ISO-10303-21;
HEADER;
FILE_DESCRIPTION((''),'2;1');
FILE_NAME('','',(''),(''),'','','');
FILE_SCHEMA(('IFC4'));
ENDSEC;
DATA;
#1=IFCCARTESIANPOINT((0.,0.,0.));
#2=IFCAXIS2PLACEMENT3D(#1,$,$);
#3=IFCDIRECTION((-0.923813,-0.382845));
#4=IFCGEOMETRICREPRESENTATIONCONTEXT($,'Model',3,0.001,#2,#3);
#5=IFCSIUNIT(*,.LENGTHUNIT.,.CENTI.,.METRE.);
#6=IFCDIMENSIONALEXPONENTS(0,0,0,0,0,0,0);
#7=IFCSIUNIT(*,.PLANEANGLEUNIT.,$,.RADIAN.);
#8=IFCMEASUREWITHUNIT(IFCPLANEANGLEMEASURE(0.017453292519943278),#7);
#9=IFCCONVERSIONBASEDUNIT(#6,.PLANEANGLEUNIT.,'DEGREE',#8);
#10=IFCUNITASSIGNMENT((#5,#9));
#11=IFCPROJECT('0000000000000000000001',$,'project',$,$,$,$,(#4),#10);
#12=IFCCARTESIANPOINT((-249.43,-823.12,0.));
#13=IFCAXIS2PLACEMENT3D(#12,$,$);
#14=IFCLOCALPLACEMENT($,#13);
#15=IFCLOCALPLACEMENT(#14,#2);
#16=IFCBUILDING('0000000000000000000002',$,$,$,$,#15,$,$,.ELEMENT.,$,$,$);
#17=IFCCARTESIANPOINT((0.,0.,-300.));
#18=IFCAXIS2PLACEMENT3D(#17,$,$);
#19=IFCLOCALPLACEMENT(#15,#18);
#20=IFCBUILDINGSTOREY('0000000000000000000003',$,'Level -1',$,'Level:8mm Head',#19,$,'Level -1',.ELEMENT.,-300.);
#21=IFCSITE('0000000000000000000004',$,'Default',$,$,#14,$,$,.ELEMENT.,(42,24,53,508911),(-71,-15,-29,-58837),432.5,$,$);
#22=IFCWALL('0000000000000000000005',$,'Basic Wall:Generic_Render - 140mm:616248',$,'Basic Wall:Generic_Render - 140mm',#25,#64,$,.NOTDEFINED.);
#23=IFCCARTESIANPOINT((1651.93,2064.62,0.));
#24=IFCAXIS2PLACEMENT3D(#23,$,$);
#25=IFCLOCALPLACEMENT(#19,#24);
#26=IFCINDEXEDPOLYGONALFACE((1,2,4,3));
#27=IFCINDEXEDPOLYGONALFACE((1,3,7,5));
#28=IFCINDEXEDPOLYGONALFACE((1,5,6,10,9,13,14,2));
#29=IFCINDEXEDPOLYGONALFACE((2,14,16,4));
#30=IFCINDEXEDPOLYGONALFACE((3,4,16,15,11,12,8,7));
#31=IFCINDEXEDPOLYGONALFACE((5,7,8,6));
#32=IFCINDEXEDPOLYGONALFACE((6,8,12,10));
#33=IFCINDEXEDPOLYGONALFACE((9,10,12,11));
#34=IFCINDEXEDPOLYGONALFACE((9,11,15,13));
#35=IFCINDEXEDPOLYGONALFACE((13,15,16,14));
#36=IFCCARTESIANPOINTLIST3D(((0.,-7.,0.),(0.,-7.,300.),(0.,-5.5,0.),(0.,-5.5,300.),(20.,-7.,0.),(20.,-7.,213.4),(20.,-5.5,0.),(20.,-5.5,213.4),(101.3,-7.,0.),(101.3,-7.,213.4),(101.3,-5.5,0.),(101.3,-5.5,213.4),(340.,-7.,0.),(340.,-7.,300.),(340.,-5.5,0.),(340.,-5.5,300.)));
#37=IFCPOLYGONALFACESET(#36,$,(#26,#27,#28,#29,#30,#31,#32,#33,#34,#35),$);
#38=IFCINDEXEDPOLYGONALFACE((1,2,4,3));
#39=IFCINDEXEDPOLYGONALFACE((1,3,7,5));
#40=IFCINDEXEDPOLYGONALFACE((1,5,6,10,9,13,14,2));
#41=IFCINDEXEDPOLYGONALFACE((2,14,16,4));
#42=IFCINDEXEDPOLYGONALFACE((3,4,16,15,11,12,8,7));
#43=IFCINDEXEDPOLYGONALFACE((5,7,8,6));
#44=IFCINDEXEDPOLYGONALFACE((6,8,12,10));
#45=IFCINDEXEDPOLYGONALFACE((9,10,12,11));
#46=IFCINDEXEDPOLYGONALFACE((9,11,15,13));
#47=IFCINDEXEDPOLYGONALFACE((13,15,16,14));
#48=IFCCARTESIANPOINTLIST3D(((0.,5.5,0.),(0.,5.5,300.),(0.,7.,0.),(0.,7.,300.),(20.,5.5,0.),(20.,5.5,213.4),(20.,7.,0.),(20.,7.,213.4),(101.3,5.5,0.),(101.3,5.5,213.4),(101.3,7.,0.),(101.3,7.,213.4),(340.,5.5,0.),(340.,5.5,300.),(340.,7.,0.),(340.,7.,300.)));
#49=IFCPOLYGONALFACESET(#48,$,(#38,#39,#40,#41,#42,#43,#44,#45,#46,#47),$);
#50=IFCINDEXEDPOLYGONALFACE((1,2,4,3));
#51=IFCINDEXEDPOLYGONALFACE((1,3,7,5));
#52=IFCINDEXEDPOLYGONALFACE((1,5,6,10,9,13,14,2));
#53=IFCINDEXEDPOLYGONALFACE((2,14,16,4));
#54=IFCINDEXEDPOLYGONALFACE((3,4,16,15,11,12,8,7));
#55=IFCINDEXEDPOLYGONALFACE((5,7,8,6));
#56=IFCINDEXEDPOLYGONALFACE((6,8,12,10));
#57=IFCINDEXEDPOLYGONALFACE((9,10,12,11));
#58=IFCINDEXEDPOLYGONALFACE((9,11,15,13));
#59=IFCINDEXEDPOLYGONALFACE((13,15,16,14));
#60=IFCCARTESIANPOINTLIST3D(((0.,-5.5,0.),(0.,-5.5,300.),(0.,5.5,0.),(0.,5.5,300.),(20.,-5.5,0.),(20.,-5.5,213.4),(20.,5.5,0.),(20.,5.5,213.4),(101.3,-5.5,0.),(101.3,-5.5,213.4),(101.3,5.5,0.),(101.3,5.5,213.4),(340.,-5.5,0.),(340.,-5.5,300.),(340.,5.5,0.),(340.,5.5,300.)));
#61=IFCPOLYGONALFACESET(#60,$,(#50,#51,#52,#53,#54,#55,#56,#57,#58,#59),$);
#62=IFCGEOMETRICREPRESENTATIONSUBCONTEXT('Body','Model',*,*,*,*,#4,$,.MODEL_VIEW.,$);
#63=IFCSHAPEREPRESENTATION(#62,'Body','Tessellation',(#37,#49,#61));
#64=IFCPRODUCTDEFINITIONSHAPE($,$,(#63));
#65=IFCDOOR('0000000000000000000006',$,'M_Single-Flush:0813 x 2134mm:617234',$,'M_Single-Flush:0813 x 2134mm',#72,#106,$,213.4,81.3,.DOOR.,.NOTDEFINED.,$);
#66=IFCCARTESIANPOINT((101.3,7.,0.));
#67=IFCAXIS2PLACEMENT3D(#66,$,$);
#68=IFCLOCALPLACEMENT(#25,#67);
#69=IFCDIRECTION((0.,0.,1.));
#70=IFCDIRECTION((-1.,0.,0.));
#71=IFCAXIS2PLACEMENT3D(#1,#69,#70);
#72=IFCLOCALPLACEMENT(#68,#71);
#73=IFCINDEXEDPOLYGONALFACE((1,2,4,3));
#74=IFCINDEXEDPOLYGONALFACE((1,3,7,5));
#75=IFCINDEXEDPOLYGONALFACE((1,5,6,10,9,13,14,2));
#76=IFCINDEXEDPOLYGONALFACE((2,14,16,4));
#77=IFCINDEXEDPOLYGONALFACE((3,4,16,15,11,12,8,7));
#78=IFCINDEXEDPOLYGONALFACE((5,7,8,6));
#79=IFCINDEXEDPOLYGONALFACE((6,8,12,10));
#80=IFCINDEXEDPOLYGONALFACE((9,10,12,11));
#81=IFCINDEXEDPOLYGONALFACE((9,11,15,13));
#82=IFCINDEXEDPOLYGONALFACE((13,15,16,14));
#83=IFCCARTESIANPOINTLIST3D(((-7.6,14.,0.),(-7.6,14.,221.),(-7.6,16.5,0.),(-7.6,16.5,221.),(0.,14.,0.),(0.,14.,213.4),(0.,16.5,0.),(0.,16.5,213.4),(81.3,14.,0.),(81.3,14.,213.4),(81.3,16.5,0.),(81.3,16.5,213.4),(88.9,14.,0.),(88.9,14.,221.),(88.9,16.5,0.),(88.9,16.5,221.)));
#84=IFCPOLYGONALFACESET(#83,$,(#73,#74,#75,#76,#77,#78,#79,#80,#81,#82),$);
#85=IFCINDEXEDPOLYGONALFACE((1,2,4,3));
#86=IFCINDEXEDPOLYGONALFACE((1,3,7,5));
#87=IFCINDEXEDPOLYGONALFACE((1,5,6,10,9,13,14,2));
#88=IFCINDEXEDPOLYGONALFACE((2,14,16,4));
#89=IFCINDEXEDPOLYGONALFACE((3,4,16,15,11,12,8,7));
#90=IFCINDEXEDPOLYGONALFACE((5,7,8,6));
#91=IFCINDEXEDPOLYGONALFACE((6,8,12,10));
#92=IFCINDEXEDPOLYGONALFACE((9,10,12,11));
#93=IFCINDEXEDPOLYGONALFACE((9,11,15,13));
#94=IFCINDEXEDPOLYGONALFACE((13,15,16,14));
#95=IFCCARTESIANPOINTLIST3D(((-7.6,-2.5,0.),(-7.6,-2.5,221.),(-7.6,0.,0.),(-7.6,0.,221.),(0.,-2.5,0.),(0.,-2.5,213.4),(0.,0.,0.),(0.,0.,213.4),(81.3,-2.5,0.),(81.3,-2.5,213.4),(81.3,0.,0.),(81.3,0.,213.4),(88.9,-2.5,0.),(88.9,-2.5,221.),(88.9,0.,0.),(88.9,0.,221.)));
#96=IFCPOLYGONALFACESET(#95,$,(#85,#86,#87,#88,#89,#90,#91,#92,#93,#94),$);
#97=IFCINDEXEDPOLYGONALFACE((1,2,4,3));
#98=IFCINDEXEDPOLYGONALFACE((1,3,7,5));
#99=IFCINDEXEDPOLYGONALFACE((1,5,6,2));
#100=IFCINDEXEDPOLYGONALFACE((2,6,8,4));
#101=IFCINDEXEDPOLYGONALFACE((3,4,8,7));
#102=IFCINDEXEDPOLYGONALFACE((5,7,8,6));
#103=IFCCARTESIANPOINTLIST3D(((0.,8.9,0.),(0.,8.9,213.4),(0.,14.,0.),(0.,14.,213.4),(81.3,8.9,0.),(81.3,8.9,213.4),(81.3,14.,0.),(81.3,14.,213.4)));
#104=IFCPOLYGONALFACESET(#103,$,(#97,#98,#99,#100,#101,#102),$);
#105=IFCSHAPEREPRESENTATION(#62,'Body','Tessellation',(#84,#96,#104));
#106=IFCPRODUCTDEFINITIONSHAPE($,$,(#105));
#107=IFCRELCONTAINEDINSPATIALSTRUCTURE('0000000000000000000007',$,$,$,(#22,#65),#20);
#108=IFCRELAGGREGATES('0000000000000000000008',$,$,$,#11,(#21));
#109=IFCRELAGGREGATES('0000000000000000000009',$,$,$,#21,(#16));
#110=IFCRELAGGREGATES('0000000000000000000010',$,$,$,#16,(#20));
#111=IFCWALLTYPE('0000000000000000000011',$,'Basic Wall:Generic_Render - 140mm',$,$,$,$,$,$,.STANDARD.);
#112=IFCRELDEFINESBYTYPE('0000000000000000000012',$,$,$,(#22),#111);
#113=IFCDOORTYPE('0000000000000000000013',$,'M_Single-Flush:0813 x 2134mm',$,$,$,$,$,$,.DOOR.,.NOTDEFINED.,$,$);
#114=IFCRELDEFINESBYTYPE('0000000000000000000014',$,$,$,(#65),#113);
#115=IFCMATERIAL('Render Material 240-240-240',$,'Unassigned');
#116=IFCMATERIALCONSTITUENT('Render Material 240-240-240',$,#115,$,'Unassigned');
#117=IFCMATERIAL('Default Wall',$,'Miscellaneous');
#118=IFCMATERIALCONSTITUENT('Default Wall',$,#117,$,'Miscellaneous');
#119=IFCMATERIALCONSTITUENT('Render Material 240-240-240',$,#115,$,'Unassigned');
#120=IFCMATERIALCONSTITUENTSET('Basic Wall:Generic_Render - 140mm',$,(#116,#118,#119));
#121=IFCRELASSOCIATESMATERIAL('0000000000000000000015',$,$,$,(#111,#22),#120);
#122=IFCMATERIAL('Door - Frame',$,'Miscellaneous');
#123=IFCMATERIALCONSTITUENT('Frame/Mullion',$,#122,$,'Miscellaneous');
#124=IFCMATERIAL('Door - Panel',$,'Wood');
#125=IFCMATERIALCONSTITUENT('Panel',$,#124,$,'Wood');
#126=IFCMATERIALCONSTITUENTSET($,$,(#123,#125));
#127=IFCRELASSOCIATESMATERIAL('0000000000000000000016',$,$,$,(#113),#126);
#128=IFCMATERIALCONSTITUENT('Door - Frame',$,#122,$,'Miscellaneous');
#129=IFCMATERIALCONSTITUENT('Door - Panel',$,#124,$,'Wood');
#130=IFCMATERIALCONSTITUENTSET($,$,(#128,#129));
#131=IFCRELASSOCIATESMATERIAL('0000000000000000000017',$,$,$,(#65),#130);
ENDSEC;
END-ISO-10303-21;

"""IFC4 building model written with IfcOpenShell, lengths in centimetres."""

from ifc_helpers import new_model, entity, si_unit, converted_unit, direction, frame, origin, place, context, subcontext, project, spatial, indexed_curve, outline, extrude, source, transform, mapped, material, constituent, constituent_set, type_object, type_shapes, element, fill, save


model = new_model("IFC4")

# Units and contexts
model_context = context("Model", 3, precision=0.001, world=origin(), true_north=direction((-0.923813, -0.382845)))
body_context = subcontext(model_context, "Body", "Model", "MODEL_VIEW")
ifc_project = project(units=[si_unit("LENGTHUNIT", "METRE", prefix="CENTI"), converted_unit("PLANEANGLEUNIT", "DEGREE", entity("IfcPlaneAngleMeasure", 0.017453292519943278), si_unit("PLANEANGLEUNIT", "RADIAN"), dimensions=[0, 0, 0, 0, 0, 0, 0])], contexts=[model_context])

# Site, building, storey
site_placement = place(None, frame((-249.43, -823.12, 0.0)))
site = spatial("IfcSite", under=ifc_project, at=site_placement, Name="Default", CompositionType="ELEMENT", RefLatitude=(42, 24, 53, 508911), RefLongitude=(-71, -15, -29, -58837), RefElevation=432.5)
building_placement = place(site_placement, origin())
building = spatial("IfcBuilding", under=site, at=building_placement, CompositionType="ELEMENT")
storey_placement = place(building_placement, frame((0.0, 0.0, -300.0)))
storey = spatial("IfcBuildingStorey", under=building, at=storey_placement, Name="Level -1", ObjectType="Level:8mm Head", LongName="Level -1", CompositionType="ELEMENT", Elevation=-300.0)

# Wall, opening, door
ifc_material_1 = material(Name="Render Material 240-240-240", Category="Unassigned")
ifc_constituent_1 = constituent(ifc_material_1, Name="Render Material 240-240-240", Category="Unassigned")
ifc_material_2 = material(Name="Default Wall", Category="Miscellaneous")
ifc_constituent_2 = constituent(ifc_material_2, Name="Default Wall", Category="Miscellaneous")
ifc_constituent_3 = constituent(ifc_material_1, Name="Render Material 240-240-240", Category="Unassigned")
ifc_constituent_set_1 = constituent_set(constituents=[ifc_constituent_1, ifc_constituent_2, ifc_constituent_3], Name="Basic Wall:Generic_Render - 140mm")
wall_type_1 = type_object("IfcWallType", Name="Basic Wall:Generic_Render - 140mm", PredefinedType="STANDARD", material=ifc_constituent_set_1)
wall_1_placement = place(storey_placement, frame((1651.93, 2064.62, 0.0)))
wall_1 = element("IfcWall", 1, at=wall_1_placement, inside=storey, type_object=wall_type_1, material=ifc_constituent_set_1, Name="Basic Wall:Generic_Render - 140mm:616248", ObjectType="Basic Wall:Generic_Render - 140mm", PredefinedType="NOTDEFINED", context=body_context, shape_type="SweptSolid", body=[
    extrude(outline(indexed_curve([(-115.33, -171.65), (224.67, -171.65), (224.67, 128.35), (-14.02, 128.35), (-14.02, -85.05), (-95.32, -85.05), (-95.32, 128.35), (-115.32, 128.35), (-115.33, -171.65)], self_intersect=False)), frame((115.33, -7.0, 128.35), z_axis=(0.0, 1.0, 0.0), x_axis=(1.0, 0.0, 0.0)), (0.0, 0.0, 1.0), 1.5),
    extrude(outline(indexed_curve([(-128.35, -115.32), (171.65, -115.32), (171.65, 224.67), (-128.35, 224.67), (-128.35, -14.02), (85.05, -14.02), (85.05, -95.32), (-128.35, -95.32), (-128.35, -115.32)], self_intersect=False)), frame((115.33, 5.5, 128.35), z_axis=(0.0, 1.0, 0.0), x_axis=(0.0, 0.0, 1.0)), (0.0, 0.0, 1.0), 1.5),
    extrude(outline(indexed_curve([(-128.35, -115.32), (171.65, -115.32), (171.65, 224.67), (-128.35, 224.67), (-128.35, -14.02), (85.05, -14.02), (85.05, -95.32), (-128.35, -95.32), (-128.35, -115.32)], self_intersect=False)), frame((115.33, -5.5, 128.35), z_axis=(0.0, 1.0, 0.0), x_axis=(0.0, 0.0, 1.0)), (0.0, 0.0, 1.0), 11.0),
])
opening_1_placement = place(wall_1_placement, frame((101.3, 7.0, 0.0)))
opening_1 = element("IfcOpeningElement", 2, at=opening_1_placement, cuts=wall_1, PredefinedType="OPENING", context=body_context, shape_type="SweptSolid", body=[
    extrude(outline(indexed_curve([(0.0, 0.0), (213.4, 0.0), (213.4, 81.3), (0.0, 81.3), (0.0, 0.0)], self_intersect=False)), frame((0.0, 0.0, 0.0), z_axis=(0.0, -1.0, 0.0), x_axis=(0.0, 0.0, 1.0)), (0.0, 0.0, 1.0), 14.0),
])
ifc_material_3 = material(Name="Door - Frame", Category="Miscellaneous")
ifc_constituent_4 = constituent(ifc_material_3, Name="Door - Frame", Category="Miscellaneous")
ifc_material_4 = material(Name="Door - Panel", Category="Wood")
ifc_constituent_5 = constituent(ifc_material_4, Name="Door - Panel", Category="Wood")
ifc_constituent_set_2 = constituent_set(constituents=[ifc_constituent_4, ifc_constituent_5])
ifc_constituent_6 = constituent(ifc_material_3, Name="Frame/Mullion", Category="Miscellaneous")
ifc_constituent_7 = constituent(ifc_material_4, Name="Panel", Category="Wood")
ifc_constituent_set_3 = constituent_set(constituents=[ifc_constituent_6, ifc_constituent_7])
door_type_1 = type_object("IfcDoorType", Name="M_Single-Flush:0813 x 2134mm", OperationType="NOTDEFINED", PredefinedType="DOOR", material=ifc_constituent_set_3)
shared_shape_1 = source(origin(), body_context, "Body", "SweptSolid", [
    extrude(outline(indexed_curve([(-48.25, -112.4), (48.25, -112.4), (48.25, 108.6), (40.65, 108.6), (40.65, -104.8), (-40.65, -104.8), (-40.65, 108.6), (-48.25, 108.6), (-48.25, -112.4)], self_intersect=False)), frame((40.65, 14.0, 108.6), z_axis=(0.0, 1.0, 0.0), x_axis=(1.0, 0.0, 0.0)), (0.0, 0.0, 1.0), 2.5),
    extrude(outline(indexed_curve([(-112.4, -48.25), (108.6, -48.25), (108.6, -40.65), (-104.8, -40.65), (-104.8, 40.65), (108.6, 40.65), (108.6, 48.25), (-112.4, 48.25), (-112.4, -48.25)], self_intersect=False)), frame((40.65, -2.5, 108.6), z_axis=(0.0, 1.0, 0.0), x_axis=(0.0, 0.0, -1.0)), (0.0, 0.0, 1.0), 2.5),
    extrude(outline(indexed_curve([(-2.55, -40.65), (2.55, -40.65), (2.55, 40.65), (-2.55, 40.65), (-2.55, -40.65)], self_intersect=False)), frame((40.65, 11.45, 0.0), z_axis=(0.0, 0.0, 1.0), x_axis=(0.0, 1.0, 0.0)), (0.0, 0.0, 1.0), 213.4),
])
type_shapes(door_type_1, [shared_shape_1])
door_1_placement = place(opening_1_placement, frame((0.0, 0.0, 0.0), z_axis=(0.0, 0.0, 1.0), x_axis=(-1.0, 0.0, 0.0)))
door_1 = element("IfcDoor", 3, at=door_1_placement, inside=storey, type_object=door_type_1, material=ifc_constituent_set_2, Name="M_Single-Flush:0813 x 2134mm:617234", ObjectType="M_Single-Flush:0813 x 2134mm", OperationType="NOTDEFINED", OverallHeight=213.4, OverallWidth=81.3, PredefinedType="DOOR", context=body_context, shape_type="MappedRepresentation", body=[
    mapped(shared_shape_1, transform((0.0, 0.0, 0.0), scale=1.0)),
])
fill(opening_1, door_1)

save(model, "model.ifc")
